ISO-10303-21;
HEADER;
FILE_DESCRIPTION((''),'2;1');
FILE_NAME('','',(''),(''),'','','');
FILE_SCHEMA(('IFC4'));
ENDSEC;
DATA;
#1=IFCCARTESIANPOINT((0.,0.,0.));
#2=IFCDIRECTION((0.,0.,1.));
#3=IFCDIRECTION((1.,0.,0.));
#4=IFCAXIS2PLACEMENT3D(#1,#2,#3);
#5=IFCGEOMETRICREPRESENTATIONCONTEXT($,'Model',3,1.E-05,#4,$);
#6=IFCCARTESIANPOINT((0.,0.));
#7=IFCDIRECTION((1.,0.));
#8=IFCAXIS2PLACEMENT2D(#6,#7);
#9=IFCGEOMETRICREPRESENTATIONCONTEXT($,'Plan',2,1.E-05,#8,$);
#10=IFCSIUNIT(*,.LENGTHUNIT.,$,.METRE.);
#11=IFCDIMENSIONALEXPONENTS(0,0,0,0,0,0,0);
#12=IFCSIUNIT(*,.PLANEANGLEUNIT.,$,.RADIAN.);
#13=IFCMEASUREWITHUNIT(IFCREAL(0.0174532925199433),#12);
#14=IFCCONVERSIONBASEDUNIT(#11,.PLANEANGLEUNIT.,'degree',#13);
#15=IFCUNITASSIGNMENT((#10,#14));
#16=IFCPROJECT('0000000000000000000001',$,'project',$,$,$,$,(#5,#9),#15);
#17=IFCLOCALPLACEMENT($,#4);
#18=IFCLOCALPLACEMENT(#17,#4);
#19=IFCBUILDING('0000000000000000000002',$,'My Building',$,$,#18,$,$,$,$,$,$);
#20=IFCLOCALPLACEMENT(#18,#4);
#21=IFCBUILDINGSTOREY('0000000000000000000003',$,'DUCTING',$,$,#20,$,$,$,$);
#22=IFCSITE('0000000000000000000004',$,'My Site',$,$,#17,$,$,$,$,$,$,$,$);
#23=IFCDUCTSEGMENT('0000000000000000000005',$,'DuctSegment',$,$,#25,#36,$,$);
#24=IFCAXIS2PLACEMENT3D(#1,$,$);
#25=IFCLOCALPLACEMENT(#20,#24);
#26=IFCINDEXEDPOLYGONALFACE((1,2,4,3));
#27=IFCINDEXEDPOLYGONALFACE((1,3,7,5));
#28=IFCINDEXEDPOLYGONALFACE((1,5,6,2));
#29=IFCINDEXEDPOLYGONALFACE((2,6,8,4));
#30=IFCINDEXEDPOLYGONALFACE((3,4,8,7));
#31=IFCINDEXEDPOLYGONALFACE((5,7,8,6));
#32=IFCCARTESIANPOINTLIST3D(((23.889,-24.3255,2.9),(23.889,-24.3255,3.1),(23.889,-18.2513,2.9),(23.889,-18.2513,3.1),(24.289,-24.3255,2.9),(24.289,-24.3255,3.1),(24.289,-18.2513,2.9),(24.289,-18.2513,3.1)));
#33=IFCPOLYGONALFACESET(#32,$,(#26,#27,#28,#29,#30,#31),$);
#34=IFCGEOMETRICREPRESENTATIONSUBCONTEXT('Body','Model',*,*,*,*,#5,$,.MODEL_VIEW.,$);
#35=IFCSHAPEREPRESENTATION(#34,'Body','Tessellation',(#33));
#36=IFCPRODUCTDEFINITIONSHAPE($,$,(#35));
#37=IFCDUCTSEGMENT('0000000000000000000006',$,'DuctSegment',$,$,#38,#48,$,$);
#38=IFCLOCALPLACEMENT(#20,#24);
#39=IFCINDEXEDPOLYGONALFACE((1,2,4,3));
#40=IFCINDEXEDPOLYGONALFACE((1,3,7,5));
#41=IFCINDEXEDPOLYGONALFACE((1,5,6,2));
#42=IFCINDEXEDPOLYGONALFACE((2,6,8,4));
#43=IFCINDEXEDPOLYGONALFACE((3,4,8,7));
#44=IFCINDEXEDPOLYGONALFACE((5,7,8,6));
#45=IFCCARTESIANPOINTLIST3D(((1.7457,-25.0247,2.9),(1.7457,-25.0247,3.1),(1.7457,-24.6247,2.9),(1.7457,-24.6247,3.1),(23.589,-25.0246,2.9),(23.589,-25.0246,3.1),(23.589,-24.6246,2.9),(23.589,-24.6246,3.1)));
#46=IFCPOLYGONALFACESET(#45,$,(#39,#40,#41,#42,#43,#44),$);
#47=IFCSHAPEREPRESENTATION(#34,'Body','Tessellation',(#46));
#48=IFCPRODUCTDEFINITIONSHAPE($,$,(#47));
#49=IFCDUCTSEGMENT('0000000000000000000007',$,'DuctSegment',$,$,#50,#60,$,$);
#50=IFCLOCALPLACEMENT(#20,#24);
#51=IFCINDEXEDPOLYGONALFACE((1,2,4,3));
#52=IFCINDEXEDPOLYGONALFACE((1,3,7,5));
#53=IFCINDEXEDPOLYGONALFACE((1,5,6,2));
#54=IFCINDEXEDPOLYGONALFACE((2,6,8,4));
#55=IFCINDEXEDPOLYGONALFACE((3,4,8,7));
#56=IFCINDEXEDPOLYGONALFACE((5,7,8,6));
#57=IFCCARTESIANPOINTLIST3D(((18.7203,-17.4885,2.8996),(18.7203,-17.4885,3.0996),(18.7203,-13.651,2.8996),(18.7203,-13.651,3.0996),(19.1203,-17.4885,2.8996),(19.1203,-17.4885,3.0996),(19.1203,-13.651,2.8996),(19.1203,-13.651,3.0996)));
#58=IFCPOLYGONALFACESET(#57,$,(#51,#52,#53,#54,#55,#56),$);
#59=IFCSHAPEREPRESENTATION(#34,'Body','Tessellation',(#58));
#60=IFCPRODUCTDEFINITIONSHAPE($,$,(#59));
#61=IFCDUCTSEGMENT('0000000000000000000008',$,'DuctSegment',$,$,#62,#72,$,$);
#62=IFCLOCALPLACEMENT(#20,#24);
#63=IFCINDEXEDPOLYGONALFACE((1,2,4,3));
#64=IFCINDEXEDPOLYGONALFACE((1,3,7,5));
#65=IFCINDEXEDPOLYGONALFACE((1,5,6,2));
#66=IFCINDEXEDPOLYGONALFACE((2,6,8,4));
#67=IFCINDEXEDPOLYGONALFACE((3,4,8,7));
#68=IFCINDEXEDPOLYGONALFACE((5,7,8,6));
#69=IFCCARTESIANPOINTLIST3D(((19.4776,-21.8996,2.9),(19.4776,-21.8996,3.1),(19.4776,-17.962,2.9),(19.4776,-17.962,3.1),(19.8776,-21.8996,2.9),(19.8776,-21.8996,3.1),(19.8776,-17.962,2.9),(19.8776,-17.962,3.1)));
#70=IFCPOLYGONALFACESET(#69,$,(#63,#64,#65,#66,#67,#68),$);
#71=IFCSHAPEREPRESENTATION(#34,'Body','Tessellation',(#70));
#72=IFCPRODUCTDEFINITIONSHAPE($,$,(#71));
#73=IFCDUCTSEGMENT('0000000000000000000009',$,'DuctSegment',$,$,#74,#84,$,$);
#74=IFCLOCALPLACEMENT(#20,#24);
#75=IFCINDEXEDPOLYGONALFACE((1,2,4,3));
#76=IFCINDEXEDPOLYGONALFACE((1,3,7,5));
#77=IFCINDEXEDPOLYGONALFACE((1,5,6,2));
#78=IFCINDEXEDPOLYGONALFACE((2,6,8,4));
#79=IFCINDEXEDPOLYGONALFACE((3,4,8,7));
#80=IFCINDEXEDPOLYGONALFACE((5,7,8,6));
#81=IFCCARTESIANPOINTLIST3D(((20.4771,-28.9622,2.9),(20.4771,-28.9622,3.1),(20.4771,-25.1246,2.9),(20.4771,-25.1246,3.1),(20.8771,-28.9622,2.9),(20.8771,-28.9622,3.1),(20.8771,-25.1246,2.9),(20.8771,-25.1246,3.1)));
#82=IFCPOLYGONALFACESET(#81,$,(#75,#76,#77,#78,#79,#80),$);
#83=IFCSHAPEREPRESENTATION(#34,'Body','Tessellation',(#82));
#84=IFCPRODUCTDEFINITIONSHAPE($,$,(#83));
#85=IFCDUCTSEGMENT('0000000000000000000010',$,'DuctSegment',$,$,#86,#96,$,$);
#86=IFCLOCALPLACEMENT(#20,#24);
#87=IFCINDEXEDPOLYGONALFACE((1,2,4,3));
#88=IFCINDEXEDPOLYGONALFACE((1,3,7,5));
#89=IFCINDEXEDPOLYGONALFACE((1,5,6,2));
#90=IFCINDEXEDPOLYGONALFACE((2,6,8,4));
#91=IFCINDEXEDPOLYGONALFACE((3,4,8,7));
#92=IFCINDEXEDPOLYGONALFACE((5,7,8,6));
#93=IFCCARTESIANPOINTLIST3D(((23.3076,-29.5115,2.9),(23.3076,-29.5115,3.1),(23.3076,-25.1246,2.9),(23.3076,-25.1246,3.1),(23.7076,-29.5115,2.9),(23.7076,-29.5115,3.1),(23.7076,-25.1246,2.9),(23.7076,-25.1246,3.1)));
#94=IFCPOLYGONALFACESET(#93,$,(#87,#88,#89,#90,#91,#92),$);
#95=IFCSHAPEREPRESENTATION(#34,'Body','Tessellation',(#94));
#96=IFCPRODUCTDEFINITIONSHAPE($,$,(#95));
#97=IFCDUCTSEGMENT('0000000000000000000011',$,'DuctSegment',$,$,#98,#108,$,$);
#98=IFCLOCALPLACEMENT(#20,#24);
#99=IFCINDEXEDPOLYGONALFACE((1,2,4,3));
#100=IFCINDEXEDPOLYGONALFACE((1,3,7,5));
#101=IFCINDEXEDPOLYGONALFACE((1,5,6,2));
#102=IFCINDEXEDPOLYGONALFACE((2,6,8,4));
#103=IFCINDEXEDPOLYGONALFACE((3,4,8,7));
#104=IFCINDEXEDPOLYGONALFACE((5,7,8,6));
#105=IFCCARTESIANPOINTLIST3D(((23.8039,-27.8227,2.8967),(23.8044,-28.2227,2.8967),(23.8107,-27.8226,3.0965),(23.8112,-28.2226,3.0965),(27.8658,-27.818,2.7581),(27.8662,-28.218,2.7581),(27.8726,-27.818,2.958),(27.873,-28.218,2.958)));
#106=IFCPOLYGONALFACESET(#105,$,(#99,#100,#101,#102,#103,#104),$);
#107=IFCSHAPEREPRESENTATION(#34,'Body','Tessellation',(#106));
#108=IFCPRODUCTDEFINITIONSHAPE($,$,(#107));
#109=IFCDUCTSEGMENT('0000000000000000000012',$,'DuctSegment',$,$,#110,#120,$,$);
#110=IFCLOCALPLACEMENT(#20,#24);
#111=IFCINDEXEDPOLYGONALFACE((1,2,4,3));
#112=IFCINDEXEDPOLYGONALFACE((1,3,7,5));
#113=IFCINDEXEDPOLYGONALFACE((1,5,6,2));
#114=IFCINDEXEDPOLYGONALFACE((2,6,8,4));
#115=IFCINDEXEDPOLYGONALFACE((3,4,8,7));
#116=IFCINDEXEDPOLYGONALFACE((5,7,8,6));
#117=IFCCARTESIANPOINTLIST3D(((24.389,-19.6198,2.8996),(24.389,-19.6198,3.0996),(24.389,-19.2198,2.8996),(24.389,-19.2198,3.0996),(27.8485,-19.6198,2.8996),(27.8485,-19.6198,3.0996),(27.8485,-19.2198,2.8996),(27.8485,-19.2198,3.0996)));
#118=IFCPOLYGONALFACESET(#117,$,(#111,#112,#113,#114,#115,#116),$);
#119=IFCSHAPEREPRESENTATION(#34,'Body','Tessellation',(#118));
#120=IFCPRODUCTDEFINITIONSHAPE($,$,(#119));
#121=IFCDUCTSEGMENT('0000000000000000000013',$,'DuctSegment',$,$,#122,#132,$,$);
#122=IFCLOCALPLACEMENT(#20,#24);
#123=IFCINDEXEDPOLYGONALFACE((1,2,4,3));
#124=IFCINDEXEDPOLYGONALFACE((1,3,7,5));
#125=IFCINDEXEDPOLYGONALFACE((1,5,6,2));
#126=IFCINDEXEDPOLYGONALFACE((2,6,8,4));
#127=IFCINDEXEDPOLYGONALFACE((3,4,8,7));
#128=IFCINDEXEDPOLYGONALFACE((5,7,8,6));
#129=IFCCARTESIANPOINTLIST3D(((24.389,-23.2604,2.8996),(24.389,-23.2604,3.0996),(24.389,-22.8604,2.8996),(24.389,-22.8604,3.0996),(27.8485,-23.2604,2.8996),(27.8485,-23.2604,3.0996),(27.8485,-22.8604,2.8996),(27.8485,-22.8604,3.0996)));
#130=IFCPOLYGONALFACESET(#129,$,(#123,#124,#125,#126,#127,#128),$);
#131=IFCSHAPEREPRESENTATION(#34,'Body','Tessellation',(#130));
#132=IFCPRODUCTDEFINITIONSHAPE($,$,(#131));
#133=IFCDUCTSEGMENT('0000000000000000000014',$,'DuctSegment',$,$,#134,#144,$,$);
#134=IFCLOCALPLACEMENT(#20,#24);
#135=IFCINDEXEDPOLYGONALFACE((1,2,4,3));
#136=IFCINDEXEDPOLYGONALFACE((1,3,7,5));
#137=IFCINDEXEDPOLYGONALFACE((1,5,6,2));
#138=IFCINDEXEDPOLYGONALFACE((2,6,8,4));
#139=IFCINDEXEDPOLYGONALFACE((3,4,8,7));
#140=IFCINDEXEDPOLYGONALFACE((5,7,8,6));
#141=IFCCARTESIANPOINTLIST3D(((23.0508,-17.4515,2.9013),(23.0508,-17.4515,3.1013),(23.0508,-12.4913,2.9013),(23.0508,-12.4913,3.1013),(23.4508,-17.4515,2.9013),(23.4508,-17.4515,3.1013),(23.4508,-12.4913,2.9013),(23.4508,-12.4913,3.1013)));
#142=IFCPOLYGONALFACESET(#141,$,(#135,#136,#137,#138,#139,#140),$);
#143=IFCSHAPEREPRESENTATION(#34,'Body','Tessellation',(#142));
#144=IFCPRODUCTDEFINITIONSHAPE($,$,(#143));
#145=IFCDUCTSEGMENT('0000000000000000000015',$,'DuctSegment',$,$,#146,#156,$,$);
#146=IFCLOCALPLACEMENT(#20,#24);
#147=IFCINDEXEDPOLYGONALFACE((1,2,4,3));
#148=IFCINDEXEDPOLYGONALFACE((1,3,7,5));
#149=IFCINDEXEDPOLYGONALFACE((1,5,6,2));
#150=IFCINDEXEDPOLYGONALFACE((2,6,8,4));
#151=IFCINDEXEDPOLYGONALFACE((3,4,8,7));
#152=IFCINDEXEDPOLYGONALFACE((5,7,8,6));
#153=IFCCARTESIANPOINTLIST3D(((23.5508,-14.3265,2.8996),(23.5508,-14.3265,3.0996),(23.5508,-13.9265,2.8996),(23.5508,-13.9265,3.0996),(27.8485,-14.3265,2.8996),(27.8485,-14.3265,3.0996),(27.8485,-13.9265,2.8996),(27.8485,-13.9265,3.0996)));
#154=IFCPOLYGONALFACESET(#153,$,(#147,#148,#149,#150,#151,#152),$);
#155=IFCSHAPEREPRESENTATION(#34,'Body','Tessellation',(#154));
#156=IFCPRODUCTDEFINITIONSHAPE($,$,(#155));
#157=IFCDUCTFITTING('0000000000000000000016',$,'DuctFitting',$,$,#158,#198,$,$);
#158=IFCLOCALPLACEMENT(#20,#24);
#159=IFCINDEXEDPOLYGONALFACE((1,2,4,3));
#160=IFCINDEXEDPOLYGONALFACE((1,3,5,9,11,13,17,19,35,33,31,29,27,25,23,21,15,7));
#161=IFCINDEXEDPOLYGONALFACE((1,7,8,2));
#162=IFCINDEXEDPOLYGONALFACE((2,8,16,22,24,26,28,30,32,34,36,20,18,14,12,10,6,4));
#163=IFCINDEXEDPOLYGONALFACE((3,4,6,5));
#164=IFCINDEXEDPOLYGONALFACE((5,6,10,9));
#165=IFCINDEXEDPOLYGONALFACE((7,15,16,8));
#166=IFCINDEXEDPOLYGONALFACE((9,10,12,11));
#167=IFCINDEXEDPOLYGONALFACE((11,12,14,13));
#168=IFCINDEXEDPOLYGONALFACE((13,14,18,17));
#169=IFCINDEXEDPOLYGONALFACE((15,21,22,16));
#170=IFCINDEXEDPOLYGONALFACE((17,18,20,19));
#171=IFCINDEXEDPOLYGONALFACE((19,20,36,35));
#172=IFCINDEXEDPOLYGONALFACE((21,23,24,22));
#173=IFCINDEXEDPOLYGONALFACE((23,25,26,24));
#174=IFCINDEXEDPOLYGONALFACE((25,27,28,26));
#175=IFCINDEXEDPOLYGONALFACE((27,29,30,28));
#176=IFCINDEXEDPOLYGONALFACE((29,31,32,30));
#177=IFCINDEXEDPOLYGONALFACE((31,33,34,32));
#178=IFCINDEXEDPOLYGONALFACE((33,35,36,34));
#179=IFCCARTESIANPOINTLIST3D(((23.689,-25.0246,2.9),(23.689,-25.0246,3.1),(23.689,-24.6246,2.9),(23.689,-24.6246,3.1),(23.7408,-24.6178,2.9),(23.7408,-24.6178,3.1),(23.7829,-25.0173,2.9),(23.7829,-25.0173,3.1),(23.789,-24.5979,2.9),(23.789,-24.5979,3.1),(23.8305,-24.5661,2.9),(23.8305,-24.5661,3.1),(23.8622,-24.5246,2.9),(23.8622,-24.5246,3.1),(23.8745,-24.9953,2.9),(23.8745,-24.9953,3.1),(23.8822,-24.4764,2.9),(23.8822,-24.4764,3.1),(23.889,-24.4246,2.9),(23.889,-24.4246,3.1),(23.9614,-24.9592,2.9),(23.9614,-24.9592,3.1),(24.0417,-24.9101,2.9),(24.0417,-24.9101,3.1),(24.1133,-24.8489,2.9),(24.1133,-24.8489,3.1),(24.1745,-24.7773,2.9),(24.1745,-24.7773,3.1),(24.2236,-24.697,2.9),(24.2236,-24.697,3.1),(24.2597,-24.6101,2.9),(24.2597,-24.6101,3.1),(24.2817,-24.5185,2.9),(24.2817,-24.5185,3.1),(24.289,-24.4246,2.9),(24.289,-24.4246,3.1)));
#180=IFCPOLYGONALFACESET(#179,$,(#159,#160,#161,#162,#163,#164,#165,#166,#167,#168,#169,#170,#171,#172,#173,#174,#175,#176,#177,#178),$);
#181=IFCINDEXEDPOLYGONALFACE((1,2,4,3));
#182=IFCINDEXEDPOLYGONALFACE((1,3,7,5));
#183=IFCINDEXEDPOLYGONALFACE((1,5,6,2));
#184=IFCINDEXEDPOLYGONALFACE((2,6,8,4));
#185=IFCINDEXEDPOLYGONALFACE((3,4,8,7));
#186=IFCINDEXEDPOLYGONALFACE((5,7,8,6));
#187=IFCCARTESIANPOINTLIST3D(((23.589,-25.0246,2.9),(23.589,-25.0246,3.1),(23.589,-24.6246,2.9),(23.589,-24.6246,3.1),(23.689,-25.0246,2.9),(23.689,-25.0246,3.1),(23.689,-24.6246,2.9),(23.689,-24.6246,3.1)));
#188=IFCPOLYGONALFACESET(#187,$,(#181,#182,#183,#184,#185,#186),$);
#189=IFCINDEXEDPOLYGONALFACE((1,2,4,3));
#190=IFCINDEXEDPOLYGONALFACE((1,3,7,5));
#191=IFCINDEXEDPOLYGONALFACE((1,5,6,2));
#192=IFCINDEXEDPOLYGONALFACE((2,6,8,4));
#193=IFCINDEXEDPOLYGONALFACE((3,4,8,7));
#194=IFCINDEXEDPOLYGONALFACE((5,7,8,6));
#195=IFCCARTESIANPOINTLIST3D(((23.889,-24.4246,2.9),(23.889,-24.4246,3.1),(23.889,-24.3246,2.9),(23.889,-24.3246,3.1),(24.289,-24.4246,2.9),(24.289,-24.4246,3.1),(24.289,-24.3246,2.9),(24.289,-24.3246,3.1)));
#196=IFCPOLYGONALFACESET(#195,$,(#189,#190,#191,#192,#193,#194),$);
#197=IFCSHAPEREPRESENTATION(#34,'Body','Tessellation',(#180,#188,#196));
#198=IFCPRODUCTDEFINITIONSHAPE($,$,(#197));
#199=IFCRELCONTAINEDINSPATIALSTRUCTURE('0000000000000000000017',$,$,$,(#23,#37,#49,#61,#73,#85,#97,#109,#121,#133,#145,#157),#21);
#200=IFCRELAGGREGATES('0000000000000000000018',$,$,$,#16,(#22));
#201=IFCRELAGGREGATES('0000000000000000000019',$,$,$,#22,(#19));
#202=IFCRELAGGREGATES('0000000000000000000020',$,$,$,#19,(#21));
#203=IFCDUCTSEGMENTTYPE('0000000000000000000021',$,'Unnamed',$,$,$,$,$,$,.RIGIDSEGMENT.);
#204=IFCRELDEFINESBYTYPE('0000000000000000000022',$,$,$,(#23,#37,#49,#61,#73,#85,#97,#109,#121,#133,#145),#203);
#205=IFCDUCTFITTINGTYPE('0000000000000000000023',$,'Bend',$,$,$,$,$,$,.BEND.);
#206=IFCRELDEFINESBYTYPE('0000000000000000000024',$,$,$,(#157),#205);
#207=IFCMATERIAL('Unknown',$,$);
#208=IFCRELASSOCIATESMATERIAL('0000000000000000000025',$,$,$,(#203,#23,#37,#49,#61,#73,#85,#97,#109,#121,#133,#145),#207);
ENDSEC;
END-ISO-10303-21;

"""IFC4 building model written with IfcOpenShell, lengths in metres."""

from ifc_helpers import new_model, entity, si_unit, converted_unit, frame, origin_with_axes, origin_2d_with_axis, place, context, subcontext, project, spatial, line, arc, indexed_curve, rectangle, outline, extrude, source, transform, mapped, material, material_profile, profile_set, profile_usage, type_object, type_shapes, element, save


model = new_model("IFC4")

# Units and contexts
model_context = context("Model", 3, precision=1e-05, world=origin_with_axes())
plan_context = context("Plan", 2, precision=1e-05, world=origin_2d_with_axis())
body_context = subcontext(model_context, "Body", "Model", "MODEL_VIEW")
ifc_project = project(units=[si_unit("LENGTHUNIT", "METRE"), converted_unit("PLANEANGLEUNIT", "degree", entity("IfcReal", 0.0174532925199433), si_unit("PLANEANGLEUNIT", "RADIAN"), dimensions=[0, 0, 0, 0, 0, 0, 0])], contexts=[model_context, plan_context])

# Site, building, storey
site_placement = place(None, origin_with_axes())
site = spatial("IfcSite", under=ifc_project, at=site_placement, Name="My Site")
building_placement = place(site_placement, origin_with_axes())
building = spatial("IfcBuilding", under=site, at=building_placement, Name="My Building")
storey_placement = place(building_placement, origin_with_axes())
storey = spatial("IfcBuildingStorey", under=building, at=storey_placement, Name="DUCTING")

# Duct segments
ifc_material = material(Name="Unknown")
ifc_material_profile_1 = material_profile(ifc_material, rectangle(XDim=0.4, YDim=0.2))
ifc_profile_set_1 = profile_set([ifc_material_profile_1])
ifc_profile_usage_1 = profile_usage(ifc_profile_set_1, cardinal=5)
duct_segment_type = type_object("IfcDuctSegmentType", Name="Unnamed", PredefinedType="RIGIDSEGMENT", material=ifc_profile_set_1)
duct_segment_1_placement = place(storey_placement, frame((24.089, -18.2513, 3.0), z_axis=(0.0, -1.0, 0.0), x_axis=(1.0, 0.0, 0.0)))
element("IfcDuctSegment", 1, at=duct_segment_1_placement, inside=storey, type_object=duct_segment_type, material=ifc_profile_usage_1, Name="DuctSegment", context=body_context, shape_type="SweptSolid", body=[
    extrude(rectangle(XDim=0.4, YDim=0.2), origin_with_axes(), (0.0, 0.0, 1.0), 6.0742),
])
ifc_profile_usage_2 = profile_usage(ifc_profile_set_1, cardinal=5)
duct_segment_2_placement = place(storey_placement, frame((23.589, -24.8246, 3.0), z_axis=(-1.0, 0.0, 0.0), x_axis=(0.0, -1.0, 0.0)))
element("IfcDuctSegment", 2, at=duct_segment_2_placement, inside=storey, type_object=duct_segment_type, material=ifc_profile_usage_2, Name="DuctSegment", context=body_context, shape_type="SweptSolid", body=[
    extrude(rectangle(XDim=0.4, YDim=0.2), origin_with_axes(), (0.0, 0.0, 1.0), 21.8434),
])
ifc_profile_usage_3 = profile_usage(ifc_profile_set_1, cardinal=5)
duct_segment_3_placement = place(storey_placement, frame((18.9203, -17.4885, 2.9996), z_axis=(0.0, 1.0, 0.0), x_axis=(-1.0, 0.0, 0.0)))
element("IfcDuctSegment", 3, at=duct_segment_3_placement, inside=storey, type_object=duct_segment_type, material=ifc_profile_usage_3, Name="DuctSegment", context=body_context, shape_type="SweptSolid", body=[
    extrude(rectangle(XDim=0.4, YDim=0.2), origin_with_axes(), (0.0, 0.0, 1.0), 3.8375),
])
ifc_profile_usage_4 = profile_usage(ifc_profile_set_1, cardinal=5)
duct_segment_4_placement = place(storey_placement, frame((19.6776, -17.962, 3.0), z_axis=(0.0, -1.0, 0.0), x_axis=(1.0, 0.0, 0.0)))
element("IfcDuctSegment", 4, at=duct_segment_4_placement, inside=storey, type_object=duct_segment_type, material=ifc_profile_usage_4, Name="DuctSegment", context=body_context, shape_type="SweptSolid", body=[
    extrude(rectangle(XDim=0.4, YDim=0.2), origin_with_axes(), (0.0, 0.0, 1.0), 3.9375),
])
ifc_profile_usage_5 = profile_usage(ifc_profile_set_1, cardinal=5)
duct_segment_5_placement = place(storey_placement, frame((20.6771, -25.1246, 3.0), z_axis=(0.0, -1.0, 0.0), x_axis=(1.0, 0.0, 0.0)))
element("IfcDuctSegment", 5, at=duct_segment_5_placement, inside=storey, type_object=duct_segment_type, material=ifc_profile_usage_5, Name="DuctSegment", context=body_context, shape_type="SweptSolid", body=[
    extrude(rectangle(XDim=0.4, YDim=0.2), origin_with_axes(), (0.0, 0.0, 1.0), 3.8375),
])
ifc_profile_usage_6 = profile_usage(ifc_profile_set_1, cardinal=5)
duct_segment_6_placement = place(storey_placement, frame((23.5076, -25.1246, 3.0), z_axis=(0.0, -1.0, 0.0), x_axis=(1.0, 0.0, 0.0)))
element("IfcDuctSegment", 6, at=duct_segment_6_placement, inside=storey, type_object=duct_segment_type, material=ifc_profile_usage_6, Name="DuctSegment", context=body_context, shape_type="SweptSolid", body=[
    extrude(rectangle(XDim=0.4, YDim=0.2), origin_with_axes(), (0.0, 0.0, 1.0), 4.3869),
])
ifc_profile_usage_7 = profile_usage(ifc_profile_set_1, cardinal=5)
duct_segment_7_placement = place(storey_placement, frame((23.8075, -28.0226, 2.9966), z_axis=(0.999418, 0.001135, -0.034093), x_axis=(-0.001136, 0.999999, 0.0)))
element("IfcDuctSegment", 7, at=duct_segment_7_placement, inside=storey, type_object=duct_segment_type, material=ifc_profile_usage_7, Name="DuctSegment", context=body_context, shape_type="SweptSolid", body=[
    extrude(rectangle(XDim=0.4, YDim=0.2), origin_with_axes(), (0.0, 0.0, 1.0), 4.0642),
])
ifc_profile_usage_8 = profile_usage(ifc_profile_set_1, cardinal=5)
duct_segment_8_placement = place(storey_placement, frame((24.389, -19.4198, 2.9996), z_axis=(1.0, 0.0, 0.0), x_axis=(0.0, 1.0, 0.0)))
element("IfcDuctSegment", 8, at=duct_segment_8_placement, inside=storey, type_object=duct_segment_type, material=ifc_profile_usage_8, Name="DuctSegment", context=body_context, shape_type="SweptSolid", body=[
    extrude(rectangle(XDim=0.4, YDim=0.2), origin_with_axes(), (0.0, 0.0, 1.0), 3.4595),
])
ifc_profile_usage_9 = profile_usage(ifc_profile_set_1, cardinal=5)
duct_segment_9_placement = place(storey_placement, frame((24.389, -23.0604, 2.9996), z_axis=(1.0, 0.0, 0.0), x_axis=(0.0, 1.0, 0.0)))
element("IfcDuctSegment", 9, at=duct_segment_9_placement, inside=storey, type_object=duct_segment_type, material=ifc_profile_usage_9, Name="DuctSegment", context=body_context, shape_type="SweptSolid", body=[
    extrude(rectangle(XDim=0.4, YDim=0.2), origin_with_axes(), (0.0, 0.0, 1.0), 3.4595),
])
ifc_profile_usage_10 = profile_usage(ifc_profile_set_1, cardinal=5)
duct_segment_10_placement = place(storey_placement, frame((23.2508, -17.4515, 3.0013), z_axis=(0.0, 1.0, 0.0), x_axis=(-1.0, 0.0, 0.0)))
element("IfcDuctSegment", 10, at=duct_segment_10_placement, inside=storey, type_object=duct_segment_type, material=ifc_profile_usage_10, Name="DuctSegment", context=body_context, shape_type="SweptSolid", body=[
    extrude(rectangle(XDim=0.4, YDim=0.2), origin_with_axes(), (0.0, 0.0, 1.0), 4.9603),
])
ifc_profile_usage_11 = profile_usage(ifc_profile_set_1, cardinal=5)
duct_segment_11_placement = place(storey_placement, frame((23.5508, -14.1265, 2.9996), z_axis=(1.0, 0.0, 0.0), x_axis=(0.0, 1.0, 0.0)))
element("IfcDuctSegment", 11, at=duct_segment_11_placement, inside=storey, type_object=duct_segment_type, material=ifc_profile_usage_11, Name="DuctSegment", context=body_context, shape_type="SweptSolid", body=[
    extrude(rectangle(XDim=0.4, YDim=0.2), origin_with_axes(), (0.0, 0.0, 1.0), 4.2977),
])

# Duct fitting
duct_fitting_type_1 = type_object("IfcDuctFittingType", Name="Bend", PredefinedType="BEND")
shared_shape = source(origin_with_axes(), body_context, "Body", "SweptSolid", [
    extrude(outline(indexed_curve([(0.2, 0.0), (0.2586, -0.1414), (0.4, -0.2), (0.4, -0.6), (-0.0243, -0.4243), (-0.2, 0.0)], segments=[arc(1, 2, 3), line(3, 4), arc(4, 5, 6), line(6, 1)])), frame((0.0, -0.1, -0.1), z_axis=(0.0, -1.0, 0.0), x_axis=(1.0, 0.0, 0.0)), (0.0, 0.0, -1.0), 0.2),
    extrude(rectangle(XDim=0.4, YDim=0.2), origin_with_axes(), (0.0, 0.0, -1.0), 0.1),
    extrude(rectangle(XDim=0.4, YDim=0.2), frame((0.4, 0.0, -0.5), z_axis=(1.0, 0.0, 0.0), x_axis=(0.0, 0.0, 1.0)), (0.0, 0.0, 1.0), 0.1),
])
type_shapes(duct_fitting_type_1, [shared_shape])
for number, where, z_axis, x_axis, name in (
    (12, (23.589, -24.8246, 3.0), (-1.0, 0.0, 0.0), (0.0, 1.0, 0.0), "DuctFitting"),
):
    element("IfcDuctFitting", number, at=place(storey_placement, frame(where, z_axis=z_axis, x_axis=x_axis)), inside=storey, type_object=duct_fitting_type_1, Name=name, context=body_context, shape_type="MappedRepresentation", body=[
        mapped(shared_shape, transform((0.0, 0.0, 0.0), x_axis=(1.0, 0.0, 0.0), y_axis=(0.0, 1.0, 0.0), z_axis=(0.0, 0.0, 1.0), scale=1.0)),
    ])

save(model, "model.ifc")
